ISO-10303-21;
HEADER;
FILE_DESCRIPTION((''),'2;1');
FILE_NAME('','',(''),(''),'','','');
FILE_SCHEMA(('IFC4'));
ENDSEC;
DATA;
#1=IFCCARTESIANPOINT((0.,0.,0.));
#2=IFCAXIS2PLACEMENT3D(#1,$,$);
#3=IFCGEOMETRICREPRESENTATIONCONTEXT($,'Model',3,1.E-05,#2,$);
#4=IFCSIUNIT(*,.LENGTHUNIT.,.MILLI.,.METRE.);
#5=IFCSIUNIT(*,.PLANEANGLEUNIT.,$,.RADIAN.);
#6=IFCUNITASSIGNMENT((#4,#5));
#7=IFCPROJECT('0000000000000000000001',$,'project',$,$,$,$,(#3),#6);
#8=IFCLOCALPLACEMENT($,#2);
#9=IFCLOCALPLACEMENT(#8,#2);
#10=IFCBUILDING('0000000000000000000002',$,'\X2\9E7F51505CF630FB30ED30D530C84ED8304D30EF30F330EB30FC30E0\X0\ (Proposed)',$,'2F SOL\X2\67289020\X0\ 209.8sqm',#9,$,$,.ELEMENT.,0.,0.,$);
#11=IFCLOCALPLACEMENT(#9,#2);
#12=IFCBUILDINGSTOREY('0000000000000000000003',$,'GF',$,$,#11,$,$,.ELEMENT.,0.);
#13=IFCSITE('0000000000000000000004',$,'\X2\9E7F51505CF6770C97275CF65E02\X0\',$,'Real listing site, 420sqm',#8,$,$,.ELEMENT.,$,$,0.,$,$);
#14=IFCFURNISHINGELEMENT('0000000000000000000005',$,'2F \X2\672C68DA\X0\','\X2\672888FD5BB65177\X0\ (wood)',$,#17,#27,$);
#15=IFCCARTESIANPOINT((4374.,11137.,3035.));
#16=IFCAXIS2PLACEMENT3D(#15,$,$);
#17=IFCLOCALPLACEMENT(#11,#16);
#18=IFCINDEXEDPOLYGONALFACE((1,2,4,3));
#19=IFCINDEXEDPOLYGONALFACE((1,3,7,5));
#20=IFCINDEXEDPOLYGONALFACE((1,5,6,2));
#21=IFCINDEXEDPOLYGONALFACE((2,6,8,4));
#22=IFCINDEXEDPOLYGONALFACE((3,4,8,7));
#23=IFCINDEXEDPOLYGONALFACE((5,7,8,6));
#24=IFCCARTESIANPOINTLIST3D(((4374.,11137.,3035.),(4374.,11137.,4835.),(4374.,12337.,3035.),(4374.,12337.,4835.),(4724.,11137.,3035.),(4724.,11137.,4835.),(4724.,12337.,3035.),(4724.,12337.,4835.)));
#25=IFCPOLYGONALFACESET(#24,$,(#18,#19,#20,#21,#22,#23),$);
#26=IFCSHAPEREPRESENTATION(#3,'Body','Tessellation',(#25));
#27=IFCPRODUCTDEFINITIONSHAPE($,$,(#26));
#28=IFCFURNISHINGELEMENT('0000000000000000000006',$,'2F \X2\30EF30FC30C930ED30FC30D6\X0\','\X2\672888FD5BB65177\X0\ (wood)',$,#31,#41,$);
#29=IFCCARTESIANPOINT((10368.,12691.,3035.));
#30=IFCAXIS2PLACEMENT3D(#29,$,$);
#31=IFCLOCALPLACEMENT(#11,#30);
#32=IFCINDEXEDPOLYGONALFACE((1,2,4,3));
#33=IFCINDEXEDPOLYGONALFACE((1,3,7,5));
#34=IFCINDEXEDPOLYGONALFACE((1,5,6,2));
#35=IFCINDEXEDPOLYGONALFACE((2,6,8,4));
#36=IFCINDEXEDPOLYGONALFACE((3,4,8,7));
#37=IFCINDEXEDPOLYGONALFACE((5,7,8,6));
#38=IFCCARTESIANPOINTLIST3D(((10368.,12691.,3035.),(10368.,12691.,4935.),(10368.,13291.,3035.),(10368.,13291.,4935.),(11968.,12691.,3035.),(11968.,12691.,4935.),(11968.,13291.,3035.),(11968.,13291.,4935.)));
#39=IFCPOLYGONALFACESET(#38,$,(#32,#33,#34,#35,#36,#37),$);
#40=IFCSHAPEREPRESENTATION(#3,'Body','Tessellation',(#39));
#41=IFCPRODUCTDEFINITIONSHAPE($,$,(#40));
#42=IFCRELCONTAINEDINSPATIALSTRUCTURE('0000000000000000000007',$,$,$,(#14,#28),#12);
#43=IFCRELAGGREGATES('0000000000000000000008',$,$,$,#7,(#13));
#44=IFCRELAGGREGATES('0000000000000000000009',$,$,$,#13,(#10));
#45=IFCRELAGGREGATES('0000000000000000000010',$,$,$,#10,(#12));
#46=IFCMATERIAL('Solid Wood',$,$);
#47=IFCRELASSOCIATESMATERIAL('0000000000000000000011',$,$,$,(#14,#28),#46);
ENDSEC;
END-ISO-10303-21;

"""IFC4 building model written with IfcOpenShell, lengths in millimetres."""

from ifc_helpers import new_model, si_unit, frame, frame_2d, origin, place, context, project, spatial, rectangle, extrude, material, element, save


model = new_model("IFC4")

# Units and contexts
model_context = context("Model", 3, precision=1e-05, world=origin())
ifc_project = project(units=[si_unit("LENGTHUNIT", "METRE", prefix="MILLI"), si_unit("PLANEANGLEUNIT", "RADIAN")], contexts=[model_context])

# Site, building, storey
site_placement = place(None, origin())
site = spatial("IfcSite", under=ifc_project, at=site_placement, Name="鹿児島県霧島市", ObjectType="Real listing site, 420sqm", CompositionType="ELEMENT", RefElevation=0.0)
building_placement = place(site_placement, origin())
building = spatial("IfcBuilding", under=site, at=building_placement, Name="鹿児島・ロフト付きワンルーム (Proposed)", ObjectType="2F SOL木造 209.8sqm", CompositionType="ELEMENT", ElevationOfRefHeight=0.0, ElevationOfTerrain=0.0)
storey_placement = place(building_placement, origin())
storey = spatial("IfcBuildingStorey", under=building, at=storey_placement, Name="GF", CompositionType="ELEMENT", Elevation=0.0)

# Shared definitions
ifc_material_1 = material(Name="Solid Wood")

# Furnishing elements
furnishing_1_placement = place(storey_placement, frame((4374.0, 11137.0, 3035.0)))
element("IfcFurnishingElement", 1, at=furnishing_1_placement, inside=storey, material=ifc_material_1, Name="2F 本棚", Description="木製家具 (wood)", context=model_context, shape_type="SweptSolid", body=[
    extrude(rectangle(XDim=350.0, YDim=1200.0, at=frame_2d((175.0, 600.0))), frame((4374.0, 11137.0, 3035.0)), (0.0, 0.0, 1.0), 1800.0),
])
furnishing_2_placement = place(storey_placement, frame((10368.0, 12691.0, 3035.0)))
element("IfcFurnishingElement", 2, at=furnishing_2_placement, inside=storey, material=ifc_material_1, Name="2F ワードローブ", Description="木製家具 (wood)", context=model_context, shape_type="SweptSolid", body=[
    extrude(rectangle(XDim=1600.0, YDim=600.0, at=frame_2d((800.0, 300.0))), frame((10368.0, 12691.0, 3035.0)), (0.0, 0.0, 1.0), 1900.0),
])

save(model, "model.ifc")
